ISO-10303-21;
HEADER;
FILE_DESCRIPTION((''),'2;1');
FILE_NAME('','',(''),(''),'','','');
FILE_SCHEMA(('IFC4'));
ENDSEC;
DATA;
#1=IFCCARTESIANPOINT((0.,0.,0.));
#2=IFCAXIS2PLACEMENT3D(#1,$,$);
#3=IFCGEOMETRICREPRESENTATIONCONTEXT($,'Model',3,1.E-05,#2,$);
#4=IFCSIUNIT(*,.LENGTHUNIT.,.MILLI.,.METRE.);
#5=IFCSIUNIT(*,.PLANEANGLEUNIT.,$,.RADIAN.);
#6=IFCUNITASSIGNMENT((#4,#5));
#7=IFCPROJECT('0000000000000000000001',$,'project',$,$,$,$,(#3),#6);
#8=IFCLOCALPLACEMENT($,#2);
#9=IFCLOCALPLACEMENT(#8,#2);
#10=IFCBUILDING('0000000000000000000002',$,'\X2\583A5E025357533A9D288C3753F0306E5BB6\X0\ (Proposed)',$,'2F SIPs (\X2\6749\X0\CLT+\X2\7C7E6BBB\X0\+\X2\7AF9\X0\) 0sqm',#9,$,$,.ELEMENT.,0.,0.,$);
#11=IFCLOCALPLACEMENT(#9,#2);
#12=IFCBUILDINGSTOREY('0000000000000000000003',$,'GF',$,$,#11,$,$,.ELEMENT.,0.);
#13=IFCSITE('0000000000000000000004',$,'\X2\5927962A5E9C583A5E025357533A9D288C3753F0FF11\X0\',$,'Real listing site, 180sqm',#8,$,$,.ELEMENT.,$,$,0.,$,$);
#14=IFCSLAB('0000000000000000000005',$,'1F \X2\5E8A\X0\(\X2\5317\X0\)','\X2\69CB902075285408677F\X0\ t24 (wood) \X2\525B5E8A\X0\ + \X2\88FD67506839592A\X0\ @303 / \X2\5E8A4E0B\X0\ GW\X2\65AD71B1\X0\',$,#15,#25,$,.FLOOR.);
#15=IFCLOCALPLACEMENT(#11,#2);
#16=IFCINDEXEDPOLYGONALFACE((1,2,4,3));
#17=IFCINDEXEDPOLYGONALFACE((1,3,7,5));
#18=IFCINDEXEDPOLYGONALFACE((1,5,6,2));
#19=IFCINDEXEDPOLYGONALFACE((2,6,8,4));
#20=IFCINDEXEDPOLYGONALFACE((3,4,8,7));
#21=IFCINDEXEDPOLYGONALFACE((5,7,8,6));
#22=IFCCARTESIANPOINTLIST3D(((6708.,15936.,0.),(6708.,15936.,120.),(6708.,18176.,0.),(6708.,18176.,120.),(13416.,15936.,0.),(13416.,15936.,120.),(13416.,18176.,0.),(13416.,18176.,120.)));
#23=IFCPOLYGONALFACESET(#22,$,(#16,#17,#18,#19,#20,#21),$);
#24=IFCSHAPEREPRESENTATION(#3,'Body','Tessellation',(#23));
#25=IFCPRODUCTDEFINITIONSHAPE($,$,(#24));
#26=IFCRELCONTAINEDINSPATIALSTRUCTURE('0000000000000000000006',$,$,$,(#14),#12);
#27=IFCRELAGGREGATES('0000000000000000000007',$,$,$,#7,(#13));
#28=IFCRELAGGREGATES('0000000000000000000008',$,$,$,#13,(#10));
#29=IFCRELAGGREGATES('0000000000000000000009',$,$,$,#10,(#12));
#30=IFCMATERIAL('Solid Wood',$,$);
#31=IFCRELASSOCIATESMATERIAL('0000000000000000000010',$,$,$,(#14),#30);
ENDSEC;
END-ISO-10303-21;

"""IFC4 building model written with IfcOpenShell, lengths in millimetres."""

from ifc_helpers import new_model, si_unit, frame, frame_2d, origin, place, context, project, spatial, rectangle, extrude, material, element, save


model = new_model("IFC4")

# Units and contexts
model_context = context("Model", 3, precision=1e-05, world=origin())
ifc_project = project(units=[si_unit("LENGTHUNIT", "METRE", prefix="MILLI"), si_unit("PLANEANGLEUNIT", "RADIAN")], contexts=[model_context])

# Site, building, storey
site_placement = place(None, origin())
site = spatial("IfcSite", under=ifc_project, at=site_placement, Name="大阪府堺市南区鴨谷台１", ObjectType="Real listing site, 180sqm", CompositionType="ELEMENT", RefElevation=0.0)
building_placement = place(site_placement, origin())
building = spatial("IfcBuilding", under=site, at=building_placement, Name="堺市南区鴨谷台の家 (Proposed)", ObjectType="2F SIPs (杉CLT+籾殻+竹) 0sqm", CompositionType="ELEMENT", ElevationOfRefHeight=0.0, ElevationOfTerrain=0.0)
storey_placement = place(building_placement, origin())
storey = spatial("IfcBuildingStorey", under=building, at=storey_placement, Name="GF", CompositionType="ELEMENT", Elevation=0.0)

# Slab
ifc_material_1 = material(Name="Solid Wood")
slab_1_placement = place(storey_placement, frame((3354.0, 7968.0, 0.0)))
element("IfcSlab", 1, at=slab_1_placement, inside=storey, material=ifc_material_1, Name="1F 床(北)", Description="構造用合板 t24 (wood) 剛床 + 製材根太 @303 / 床下 GW断熱", PredefinedType="FLOOR", context=model_context, shape_type="SweptSolid", body=[
    extrude(rectangle(XDim=6708.0, YDim=2240.0, at=frame_2d((3354.0, 1120.0))), frame((3354.0, 7968.0, 0.0)), (0.0, 0.0, 1.0), 120.0),
])

save(model, "model.ifc")
